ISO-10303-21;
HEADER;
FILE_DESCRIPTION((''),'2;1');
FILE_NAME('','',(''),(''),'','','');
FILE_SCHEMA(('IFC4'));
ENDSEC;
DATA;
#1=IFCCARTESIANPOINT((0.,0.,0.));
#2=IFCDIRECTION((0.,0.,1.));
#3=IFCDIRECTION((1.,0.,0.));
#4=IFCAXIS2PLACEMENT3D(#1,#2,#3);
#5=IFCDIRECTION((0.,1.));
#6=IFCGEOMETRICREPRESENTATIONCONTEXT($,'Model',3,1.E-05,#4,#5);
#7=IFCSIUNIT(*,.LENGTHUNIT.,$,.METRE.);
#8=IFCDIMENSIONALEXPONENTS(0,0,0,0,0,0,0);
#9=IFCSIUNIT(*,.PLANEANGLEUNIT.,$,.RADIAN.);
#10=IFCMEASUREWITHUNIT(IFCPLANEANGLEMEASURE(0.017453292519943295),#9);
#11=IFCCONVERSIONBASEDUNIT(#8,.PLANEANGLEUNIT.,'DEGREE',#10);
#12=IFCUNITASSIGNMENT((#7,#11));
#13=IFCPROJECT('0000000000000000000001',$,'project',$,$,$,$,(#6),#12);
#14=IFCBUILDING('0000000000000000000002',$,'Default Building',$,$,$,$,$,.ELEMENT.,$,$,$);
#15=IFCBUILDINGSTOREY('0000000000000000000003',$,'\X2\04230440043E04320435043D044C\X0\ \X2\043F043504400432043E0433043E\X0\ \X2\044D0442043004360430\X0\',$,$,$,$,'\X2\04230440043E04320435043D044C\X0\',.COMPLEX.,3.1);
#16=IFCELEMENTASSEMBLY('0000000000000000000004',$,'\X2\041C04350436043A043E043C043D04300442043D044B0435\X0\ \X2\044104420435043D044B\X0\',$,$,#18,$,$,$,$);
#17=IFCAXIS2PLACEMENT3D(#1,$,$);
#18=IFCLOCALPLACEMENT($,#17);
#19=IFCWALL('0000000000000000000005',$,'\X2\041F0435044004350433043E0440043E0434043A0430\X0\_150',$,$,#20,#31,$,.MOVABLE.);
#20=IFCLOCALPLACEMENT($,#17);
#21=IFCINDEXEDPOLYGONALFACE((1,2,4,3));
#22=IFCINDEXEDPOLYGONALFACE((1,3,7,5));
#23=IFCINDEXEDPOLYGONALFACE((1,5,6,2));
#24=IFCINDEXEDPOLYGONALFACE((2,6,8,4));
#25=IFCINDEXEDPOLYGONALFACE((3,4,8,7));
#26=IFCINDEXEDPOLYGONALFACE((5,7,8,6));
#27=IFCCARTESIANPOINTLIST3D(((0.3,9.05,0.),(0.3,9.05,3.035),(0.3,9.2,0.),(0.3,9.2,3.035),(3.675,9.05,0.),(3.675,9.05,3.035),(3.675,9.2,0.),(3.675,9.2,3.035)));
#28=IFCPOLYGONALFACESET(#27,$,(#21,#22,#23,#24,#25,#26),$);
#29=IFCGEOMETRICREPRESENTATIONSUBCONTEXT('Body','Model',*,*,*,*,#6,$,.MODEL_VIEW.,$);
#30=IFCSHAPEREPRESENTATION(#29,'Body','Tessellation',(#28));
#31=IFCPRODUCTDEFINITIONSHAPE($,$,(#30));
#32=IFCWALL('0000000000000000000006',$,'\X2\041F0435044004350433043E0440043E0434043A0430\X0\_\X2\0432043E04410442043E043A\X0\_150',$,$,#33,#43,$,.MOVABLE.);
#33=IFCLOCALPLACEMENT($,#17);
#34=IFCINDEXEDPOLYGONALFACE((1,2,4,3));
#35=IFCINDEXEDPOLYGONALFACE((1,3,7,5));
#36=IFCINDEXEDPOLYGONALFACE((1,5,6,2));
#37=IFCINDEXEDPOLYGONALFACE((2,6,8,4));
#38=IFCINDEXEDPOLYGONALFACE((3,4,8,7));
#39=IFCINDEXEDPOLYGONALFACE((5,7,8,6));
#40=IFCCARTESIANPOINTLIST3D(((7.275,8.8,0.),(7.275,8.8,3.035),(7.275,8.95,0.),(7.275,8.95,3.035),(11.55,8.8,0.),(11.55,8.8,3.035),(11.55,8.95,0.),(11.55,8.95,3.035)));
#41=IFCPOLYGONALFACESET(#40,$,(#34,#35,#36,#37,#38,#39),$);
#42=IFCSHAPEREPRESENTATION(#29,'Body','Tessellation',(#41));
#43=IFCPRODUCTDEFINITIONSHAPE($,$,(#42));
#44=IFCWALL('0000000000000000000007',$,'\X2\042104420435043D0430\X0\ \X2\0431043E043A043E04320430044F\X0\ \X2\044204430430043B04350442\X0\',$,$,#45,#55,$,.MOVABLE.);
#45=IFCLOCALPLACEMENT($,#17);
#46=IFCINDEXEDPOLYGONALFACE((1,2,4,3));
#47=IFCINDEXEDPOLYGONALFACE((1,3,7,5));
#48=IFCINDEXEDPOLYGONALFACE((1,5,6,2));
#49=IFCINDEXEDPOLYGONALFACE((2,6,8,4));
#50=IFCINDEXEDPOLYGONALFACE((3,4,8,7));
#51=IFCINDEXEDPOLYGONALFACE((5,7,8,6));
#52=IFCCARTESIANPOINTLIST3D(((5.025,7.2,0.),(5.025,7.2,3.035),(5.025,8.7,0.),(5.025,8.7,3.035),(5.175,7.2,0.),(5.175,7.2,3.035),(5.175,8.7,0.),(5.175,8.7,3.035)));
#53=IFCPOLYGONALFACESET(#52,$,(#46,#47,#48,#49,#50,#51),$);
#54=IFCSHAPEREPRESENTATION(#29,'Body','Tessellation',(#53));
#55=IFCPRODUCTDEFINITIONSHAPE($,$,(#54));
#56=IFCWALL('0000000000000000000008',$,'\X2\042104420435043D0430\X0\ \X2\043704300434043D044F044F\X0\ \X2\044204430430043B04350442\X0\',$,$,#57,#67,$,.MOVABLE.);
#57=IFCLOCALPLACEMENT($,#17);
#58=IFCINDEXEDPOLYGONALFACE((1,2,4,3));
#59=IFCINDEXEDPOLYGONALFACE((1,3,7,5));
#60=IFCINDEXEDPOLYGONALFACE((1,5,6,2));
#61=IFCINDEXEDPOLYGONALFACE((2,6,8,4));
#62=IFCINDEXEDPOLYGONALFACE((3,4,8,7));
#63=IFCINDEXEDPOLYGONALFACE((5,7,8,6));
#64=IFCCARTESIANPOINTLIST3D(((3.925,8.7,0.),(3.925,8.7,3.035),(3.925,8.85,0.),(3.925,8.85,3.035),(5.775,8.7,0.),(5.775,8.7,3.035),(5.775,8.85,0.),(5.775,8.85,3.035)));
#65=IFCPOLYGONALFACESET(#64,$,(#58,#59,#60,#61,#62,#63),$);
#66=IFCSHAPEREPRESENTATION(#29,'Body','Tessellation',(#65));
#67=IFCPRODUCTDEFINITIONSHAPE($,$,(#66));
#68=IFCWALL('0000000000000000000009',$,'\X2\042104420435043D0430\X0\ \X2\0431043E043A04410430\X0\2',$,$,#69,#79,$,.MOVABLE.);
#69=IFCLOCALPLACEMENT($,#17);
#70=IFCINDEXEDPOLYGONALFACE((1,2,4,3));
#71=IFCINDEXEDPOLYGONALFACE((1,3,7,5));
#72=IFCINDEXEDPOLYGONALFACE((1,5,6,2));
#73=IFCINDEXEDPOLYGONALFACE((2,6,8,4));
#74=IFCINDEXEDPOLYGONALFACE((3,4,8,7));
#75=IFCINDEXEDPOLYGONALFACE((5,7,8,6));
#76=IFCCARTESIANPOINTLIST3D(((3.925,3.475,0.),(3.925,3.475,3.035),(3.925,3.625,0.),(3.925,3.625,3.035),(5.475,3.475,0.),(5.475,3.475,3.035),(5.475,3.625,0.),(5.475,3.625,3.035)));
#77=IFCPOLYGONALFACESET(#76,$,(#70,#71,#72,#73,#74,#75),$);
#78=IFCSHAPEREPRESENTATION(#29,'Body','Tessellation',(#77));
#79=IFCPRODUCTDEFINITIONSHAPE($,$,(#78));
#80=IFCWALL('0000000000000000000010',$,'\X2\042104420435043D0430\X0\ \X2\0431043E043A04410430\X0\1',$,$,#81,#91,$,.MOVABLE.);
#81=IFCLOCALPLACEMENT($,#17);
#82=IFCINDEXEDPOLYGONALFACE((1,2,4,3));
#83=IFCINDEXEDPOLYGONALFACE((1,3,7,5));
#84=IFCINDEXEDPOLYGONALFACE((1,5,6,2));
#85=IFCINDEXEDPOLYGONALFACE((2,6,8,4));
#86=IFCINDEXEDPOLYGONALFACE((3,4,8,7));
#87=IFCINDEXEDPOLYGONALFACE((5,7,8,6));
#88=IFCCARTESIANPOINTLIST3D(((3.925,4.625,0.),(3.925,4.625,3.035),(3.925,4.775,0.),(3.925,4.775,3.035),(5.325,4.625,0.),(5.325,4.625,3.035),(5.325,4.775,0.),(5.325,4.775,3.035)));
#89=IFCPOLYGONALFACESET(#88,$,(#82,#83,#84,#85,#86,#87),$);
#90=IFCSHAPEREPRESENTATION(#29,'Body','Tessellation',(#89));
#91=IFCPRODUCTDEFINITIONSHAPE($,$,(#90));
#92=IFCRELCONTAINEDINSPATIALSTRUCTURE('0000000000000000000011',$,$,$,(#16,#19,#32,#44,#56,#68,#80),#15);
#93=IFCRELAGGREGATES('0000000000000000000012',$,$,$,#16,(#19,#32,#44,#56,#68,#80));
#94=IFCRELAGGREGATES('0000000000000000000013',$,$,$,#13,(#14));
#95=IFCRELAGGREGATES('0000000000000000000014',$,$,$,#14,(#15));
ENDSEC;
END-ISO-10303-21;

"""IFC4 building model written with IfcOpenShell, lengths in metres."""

from ifc_helpers import new_model, entity, si_unit, converted_unit, direction, frame, frame_2d, origin_with_axes, origin_2d_with_axis, place, context, subcontext, project, spatial, rectangle, extrude, element, aggregate, save


model = new_model("IFC4")

# Units and contexts
model_context = context("Model", 3, precision=1e-05, world=origin_with_axes(), true_north=direction((0.0, 1.0)))
body_context = subcontext(model_context, "Body", "Model", "MODEL_VIEW")
ifc_project = project(units=[si_unit("LENGTHUNIT", "METRE"), converted_unit("PLANEANGLEUNIT", "DEGREE", entity("IfcPlaneAngleMeasure", 0.017453292519943295), si_unit("PLANEANGLEUNIT", "RADIAN"), dimensions=[0, 0, 0, 0, 0, 0, 0])], contexts=[model_context])

# Building, storey
building = spatial("IfcBuilding", under=ifc_project, Name="Default Building", CompositionType="ELEMENT")
storey = spatial("IfcBuildingStorey", under=building, Name="Уровень первого этажа", LongName="Уровень", CompositionType="COMPLEX", Elevation=3.1)

# Element assembly, walls
assembly = element("IfcElementAssembly", 1, inside=storey, Name="Межкомнатные стены")
placement = place(None, origin_with_axes())
wall_1 = element("IfcWall", 2, at=placement, inside=storey, Name="Перегородка_150", PredefinedType="MOVABLE", context=body_context, shape_type="SweptSolid", body=[
    extrude(rectangle(XDim=3.375, YDim=0.15, at=origin_2d_with_axis()), frame((1.9875, 9.125, 0.0), z_axis=(0.0, 0.0, 1.0), x_axis=(1.0, 0.0, 0.0)), (0.0, 0.0, 1.0), 3.035),
])
wall_2 = element("IfcWall", 3, at=placement, inside=storey, Name="Перегородка_восток_150", PredefinedType="MOVABLE", context=body_context, shape_type="SweptSolid", body=[
    extrude(rectangle(XDim=4.275, YDim=0.15, at=frame_2d((0.0, 0.0), x_axis=(1.0, 0.0))), frame((9.4125, 8.875, 0.0), z_axis=(0.0, 0.0, 1.0), x_axis=(1.0, 0.0, 0.0)), (0.0, 0.0, 1.0), 3.035),
])
wall_3 = element("IfcWall", 4, at=placement, inside=storey, Name="Стена боковая туалет", PredefinedType="MOVABLE", context=body_context, shape_type="SweptSolid", body=[
    extrude(rectangle(XDim=1.5, YDim=0.15, at=frame_2d((0.0, 0.0), x_axis=(0.0, 1.0))), frame((5.1, 7.95, 0.0), z_axis=(0.0, 0.0, 1.0), x_axis=(1.0, 0.0, 0.0)), (0.0, 0.0, 1.0), 3.035),
])
wall_4 = element("IfcWall", 5, at=placement, inside=storey, Name="Стена задняя туалет", PredefinedType="MOVABLE", context=body_context, shape_type="SweptSolid", body=[
    extrude(rectangle(XDim=1.85, YDim=0.15, at=frame_2d((0.0, 0.0), x_axis=(1.0, 0.0))), frame((4.85, 8.775, 0.0), z_axis=(0.0, 0.0, 1.0), x_axis=(1.0, 0.0, 0.0)), (0.0, 0.0, 1.0), 3.035),
])
wall_5 = element("IfcWall", 6, at=placement, inside=storey, Name="Стена бокса2", PredefinedType="MOVABLE", context=body_context, shape_type="SweptSolid", body=[
    extrude(rectangle(XDim=1.55, YDim=0.15, at=frame_2d((0.0, 0.0), x_axis=(1.0, 0.0))), frame((4.7, 3.55, 0.0), z_axis=(0.0, 0.0, 1.0), x_axis=(1.0, 0.0, 0.0)), (0.0, 0.0, 1.0), 3.035),
])
wall_6 = element("IfcWall", 7, at=placement, inside=storey, Name="Стена бокса1", PredefinedType="MOVABLE", context=body_context, shape_type="SweptSolid", body=[
    extrude(rectangle(XDim=1.4, YDim=0.15, at=origin_2d_with_axis()), frame((4.625, 4.7, 0.0), z_axis=(0.0, 0.0, 1.0), x_axis=(1.0, 0.0, 0.0)), (0.0, 0.0, 1.0), 3.035),
])
aggregate(assembly, [wall_1, wall_2, wall_3, wall_4, wall_5, wall_6])

save(model, "model.ifc")
